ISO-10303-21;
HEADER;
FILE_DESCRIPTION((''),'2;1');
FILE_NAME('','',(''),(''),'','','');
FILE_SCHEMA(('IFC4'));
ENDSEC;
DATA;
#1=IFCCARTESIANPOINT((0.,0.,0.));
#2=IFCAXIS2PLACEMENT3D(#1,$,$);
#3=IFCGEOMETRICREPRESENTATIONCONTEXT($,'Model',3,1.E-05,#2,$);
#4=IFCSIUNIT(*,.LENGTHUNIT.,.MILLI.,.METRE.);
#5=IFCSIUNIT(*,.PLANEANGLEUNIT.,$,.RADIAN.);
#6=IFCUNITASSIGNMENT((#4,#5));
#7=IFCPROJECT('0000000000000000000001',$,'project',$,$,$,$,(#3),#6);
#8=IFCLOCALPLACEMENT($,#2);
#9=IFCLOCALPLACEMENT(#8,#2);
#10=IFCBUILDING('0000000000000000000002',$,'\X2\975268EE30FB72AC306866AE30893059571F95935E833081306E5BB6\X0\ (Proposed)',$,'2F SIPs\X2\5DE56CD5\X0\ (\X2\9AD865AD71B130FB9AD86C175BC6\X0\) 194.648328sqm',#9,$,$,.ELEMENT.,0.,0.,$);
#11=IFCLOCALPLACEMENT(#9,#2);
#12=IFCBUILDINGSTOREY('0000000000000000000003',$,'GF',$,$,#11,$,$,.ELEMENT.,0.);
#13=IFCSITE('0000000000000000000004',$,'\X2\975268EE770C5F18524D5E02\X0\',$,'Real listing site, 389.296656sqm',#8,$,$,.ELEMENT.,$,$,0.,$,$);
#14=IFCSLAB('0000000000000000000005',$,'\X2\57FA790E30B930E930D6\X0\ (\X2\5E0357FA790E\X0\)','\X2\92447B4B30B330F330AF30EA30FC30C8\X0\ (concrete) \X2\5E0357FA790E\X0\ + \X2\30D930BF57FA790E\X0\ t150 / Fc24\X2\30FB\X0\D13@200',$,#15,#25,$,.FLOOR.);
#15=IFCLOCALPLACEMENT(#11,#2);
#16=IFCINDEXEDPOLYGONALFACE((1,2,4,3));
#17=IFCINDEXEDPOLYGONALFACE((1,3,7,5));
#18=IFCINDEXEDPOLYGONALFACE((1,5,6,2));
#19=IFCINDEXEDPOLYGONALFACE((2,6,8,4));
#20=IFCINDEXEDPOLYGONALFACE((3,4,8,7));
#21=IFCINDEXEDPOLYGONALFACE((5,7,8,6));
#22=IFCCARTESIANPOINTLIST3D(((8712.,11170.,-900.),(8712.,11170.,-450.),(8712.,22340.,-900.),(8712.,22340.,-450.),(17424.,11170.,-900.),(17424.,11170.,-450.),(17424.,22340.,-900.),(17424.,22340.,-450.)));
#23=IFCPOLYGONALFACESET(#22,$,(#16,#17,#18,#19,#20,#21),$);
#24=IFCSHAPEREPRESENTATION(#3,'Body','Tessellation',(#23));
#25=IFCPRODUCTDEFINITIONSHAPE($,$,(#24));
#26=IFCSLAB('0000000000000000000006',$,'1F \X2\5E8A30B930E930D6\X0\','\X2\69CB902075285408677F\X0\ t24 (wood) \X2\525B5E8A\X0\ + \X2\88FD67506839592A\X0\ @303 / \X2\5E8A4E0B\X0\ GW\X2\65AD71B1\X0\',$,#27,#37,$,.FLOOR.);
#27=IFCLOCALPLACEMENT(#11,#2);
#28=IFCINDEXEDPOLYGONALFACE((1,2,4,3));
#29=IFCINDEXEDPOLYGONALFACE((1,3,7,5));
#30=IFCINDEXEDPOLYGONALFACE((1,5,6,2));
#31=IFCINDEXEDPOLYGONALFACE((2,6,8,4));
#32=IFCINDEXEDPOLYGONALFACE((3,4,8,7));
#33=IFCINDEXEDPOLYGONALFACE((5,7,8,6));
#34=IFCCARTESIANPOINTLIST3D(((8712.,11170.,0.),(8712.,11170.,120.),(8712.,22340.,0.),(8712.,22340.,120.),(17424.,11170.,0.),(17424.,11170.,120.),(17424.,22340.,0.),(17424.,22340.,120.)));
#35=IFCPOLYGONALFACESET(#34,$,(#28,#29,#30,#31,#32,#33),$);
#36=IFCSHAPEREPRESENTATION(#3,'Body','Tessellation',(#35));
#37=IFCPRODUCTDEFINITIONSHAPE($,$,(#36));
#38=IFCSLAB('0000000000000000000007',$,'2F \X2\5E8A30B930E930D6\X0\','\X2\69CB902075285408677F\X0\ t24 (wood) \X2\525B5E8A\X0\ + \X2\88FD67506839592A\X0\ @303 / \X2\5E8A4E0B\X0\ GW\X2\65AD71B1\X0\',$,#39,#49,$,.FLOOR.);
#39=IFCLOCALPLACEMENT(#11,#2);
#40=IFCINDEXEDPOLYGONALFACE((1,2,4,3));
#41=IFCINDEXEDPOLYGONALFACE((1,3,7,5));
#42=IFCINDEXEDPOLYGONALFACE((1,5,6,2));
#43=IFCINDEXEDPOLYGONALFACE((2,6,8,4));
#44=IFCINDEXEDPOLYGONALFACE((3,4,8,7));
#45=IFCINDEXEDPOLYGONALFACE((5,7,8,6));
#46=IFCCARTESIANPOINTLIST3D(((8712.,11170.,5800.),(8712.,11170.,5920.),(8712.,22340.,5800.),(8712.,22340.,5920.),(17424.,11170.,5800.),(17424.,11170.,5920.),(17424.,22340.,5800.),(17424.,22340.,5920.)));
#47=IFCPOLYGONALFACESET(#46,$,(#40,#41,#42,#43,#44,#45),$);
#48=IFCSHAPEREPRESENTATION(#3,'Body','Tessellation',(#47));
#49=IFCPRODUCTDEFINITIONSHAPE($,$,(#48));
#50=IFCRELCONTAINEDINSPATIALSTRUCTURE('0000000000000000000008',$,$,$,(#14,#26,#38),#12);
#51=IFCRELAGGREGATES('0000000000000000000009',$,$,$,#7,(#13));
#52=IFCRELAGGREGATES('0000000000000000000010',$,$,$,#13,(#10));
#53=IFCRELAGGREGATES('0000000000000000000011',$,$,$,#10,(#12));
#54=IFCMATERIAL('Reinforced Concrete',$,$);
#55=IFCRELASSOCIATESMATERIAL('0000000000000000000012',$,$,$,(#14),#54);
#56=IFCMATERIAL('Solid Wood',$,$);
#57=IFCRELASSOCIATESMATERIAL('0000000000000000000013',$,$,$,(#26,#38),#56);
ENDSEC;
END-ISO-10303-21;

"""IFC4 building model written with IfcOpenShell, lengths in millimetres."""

from ifc_helpers import new_model, si_unit, frame, frame_2d, origin, place, context, project, spatial, rectangle, extrude, material, element, save


model = new_model("IFC4")

# Units and contexts
model_context = context("Model", 3, precision=1e-05, world=origin())
ifc_project = project(units=[si_unit("LENGTHUNIT", "METRE", prefix="MILLI"), si_unit("PLANEANGLEUNIT", "RADIAN")], contexts=[model_context])

# Site, building, storey
site_placement = place(None, origin())
site = spatial("IfcSite", under=ifc_project, at=site_placement, Name="青森県弘前市", ObjectType="Real listing site, 389.296656sqm", CompositionType="ELEMENT", RefElevation=0.0)
building_placement = place(site_placement, origin())
building = spatial("IfcBuilding", under=site, at=building_placement, Name="青森・犬と暮らす土間広めの家 (Proposed)", ObjectType="2F SIPs工法 (高断熱・高気密) 194.648328sqm", CompositionType="ELEMENT", ElevationOfRefHeight=0.0, ElevationOfTerrain=0.0)
storey_placement = place(building_placement, origin())
storey = spatial("IfcBuildingStorey", under=building, at=storey_placement, Name="GF", CompositionType="ELEMENT", Elevation=0.0)

# Slabs
ifc_material_1 = material(Name="Reinforced Concrete")
slab_1_placement = place(storey_placement, frame((4356.0, 5585.0, -450.0)))
element("IfcSlab", 1, at=slab_1_placement, inside=storey, material=ifc_material_1, Name="基礎スラブ (布基礎)", Description="鉄筋コンクリート (concrete) 布基礎 + ベタ基礎 t150 / Fc24・D13@200", PredefinedType="FLOOR", context=model_context, shape_type="SweptSolid", body=[
    extrude(rectangle(XDim=8712.0, YDim=11170.0, at=frame_2d((4356.0, 5585.0))), frame((4356.0, 5585.0, -450.0)), (0.0, 0.0, 1.0), 450.0),
])
ifc_material_2 = material(Name="Solid Wood")
slab_2_placement = place(storey_placement, frame((4356.0, 5585.0, 0.0)))
element("IfcSlab", 2, at=slab_2_placement, inside=storey, material=ifc_material_2, Name="1F 床スラブ", Description="構造用合板 t24 (wood) 剛床 + 製材根太 @303 / 床下 GW断熱", PredefinedType="FLOOR", context=model_context, shape_type="SweptSolid", body=[
    extrude(rectangle(XDim=8712.0, YDim=11170.0, at=frame_2d((4356.0, 5585.0))), frame((4356.0, 5585.0, 0.0)), (0.0, 0.0, 1.0), 120.0),
])
slab_3_placement = place(storey_placement, frame((4356.0, 5585.0, 2900.0)))
element("IfcSlab", 3, at=slab_3_placement, inside=storey, material=ifc_material_2, Name="2F 床スラブ", Description="構造用合板 t24 (wood) 剛床 + 製材根太 @303 / 床下 GW断熱", PredefinedType="FLOOR", context=model_context, shape_type="SweptSolid", body=[
    extrude(rectangle(XDim=8712.0, YDim=11170.0, at=frame_2d((4356.0, 5585.0))), frame((4356.0, 5585.0, 2900.0)), (0.0, 0.0, 1.0), 120.0),
])

save(model, "model.ifc")
